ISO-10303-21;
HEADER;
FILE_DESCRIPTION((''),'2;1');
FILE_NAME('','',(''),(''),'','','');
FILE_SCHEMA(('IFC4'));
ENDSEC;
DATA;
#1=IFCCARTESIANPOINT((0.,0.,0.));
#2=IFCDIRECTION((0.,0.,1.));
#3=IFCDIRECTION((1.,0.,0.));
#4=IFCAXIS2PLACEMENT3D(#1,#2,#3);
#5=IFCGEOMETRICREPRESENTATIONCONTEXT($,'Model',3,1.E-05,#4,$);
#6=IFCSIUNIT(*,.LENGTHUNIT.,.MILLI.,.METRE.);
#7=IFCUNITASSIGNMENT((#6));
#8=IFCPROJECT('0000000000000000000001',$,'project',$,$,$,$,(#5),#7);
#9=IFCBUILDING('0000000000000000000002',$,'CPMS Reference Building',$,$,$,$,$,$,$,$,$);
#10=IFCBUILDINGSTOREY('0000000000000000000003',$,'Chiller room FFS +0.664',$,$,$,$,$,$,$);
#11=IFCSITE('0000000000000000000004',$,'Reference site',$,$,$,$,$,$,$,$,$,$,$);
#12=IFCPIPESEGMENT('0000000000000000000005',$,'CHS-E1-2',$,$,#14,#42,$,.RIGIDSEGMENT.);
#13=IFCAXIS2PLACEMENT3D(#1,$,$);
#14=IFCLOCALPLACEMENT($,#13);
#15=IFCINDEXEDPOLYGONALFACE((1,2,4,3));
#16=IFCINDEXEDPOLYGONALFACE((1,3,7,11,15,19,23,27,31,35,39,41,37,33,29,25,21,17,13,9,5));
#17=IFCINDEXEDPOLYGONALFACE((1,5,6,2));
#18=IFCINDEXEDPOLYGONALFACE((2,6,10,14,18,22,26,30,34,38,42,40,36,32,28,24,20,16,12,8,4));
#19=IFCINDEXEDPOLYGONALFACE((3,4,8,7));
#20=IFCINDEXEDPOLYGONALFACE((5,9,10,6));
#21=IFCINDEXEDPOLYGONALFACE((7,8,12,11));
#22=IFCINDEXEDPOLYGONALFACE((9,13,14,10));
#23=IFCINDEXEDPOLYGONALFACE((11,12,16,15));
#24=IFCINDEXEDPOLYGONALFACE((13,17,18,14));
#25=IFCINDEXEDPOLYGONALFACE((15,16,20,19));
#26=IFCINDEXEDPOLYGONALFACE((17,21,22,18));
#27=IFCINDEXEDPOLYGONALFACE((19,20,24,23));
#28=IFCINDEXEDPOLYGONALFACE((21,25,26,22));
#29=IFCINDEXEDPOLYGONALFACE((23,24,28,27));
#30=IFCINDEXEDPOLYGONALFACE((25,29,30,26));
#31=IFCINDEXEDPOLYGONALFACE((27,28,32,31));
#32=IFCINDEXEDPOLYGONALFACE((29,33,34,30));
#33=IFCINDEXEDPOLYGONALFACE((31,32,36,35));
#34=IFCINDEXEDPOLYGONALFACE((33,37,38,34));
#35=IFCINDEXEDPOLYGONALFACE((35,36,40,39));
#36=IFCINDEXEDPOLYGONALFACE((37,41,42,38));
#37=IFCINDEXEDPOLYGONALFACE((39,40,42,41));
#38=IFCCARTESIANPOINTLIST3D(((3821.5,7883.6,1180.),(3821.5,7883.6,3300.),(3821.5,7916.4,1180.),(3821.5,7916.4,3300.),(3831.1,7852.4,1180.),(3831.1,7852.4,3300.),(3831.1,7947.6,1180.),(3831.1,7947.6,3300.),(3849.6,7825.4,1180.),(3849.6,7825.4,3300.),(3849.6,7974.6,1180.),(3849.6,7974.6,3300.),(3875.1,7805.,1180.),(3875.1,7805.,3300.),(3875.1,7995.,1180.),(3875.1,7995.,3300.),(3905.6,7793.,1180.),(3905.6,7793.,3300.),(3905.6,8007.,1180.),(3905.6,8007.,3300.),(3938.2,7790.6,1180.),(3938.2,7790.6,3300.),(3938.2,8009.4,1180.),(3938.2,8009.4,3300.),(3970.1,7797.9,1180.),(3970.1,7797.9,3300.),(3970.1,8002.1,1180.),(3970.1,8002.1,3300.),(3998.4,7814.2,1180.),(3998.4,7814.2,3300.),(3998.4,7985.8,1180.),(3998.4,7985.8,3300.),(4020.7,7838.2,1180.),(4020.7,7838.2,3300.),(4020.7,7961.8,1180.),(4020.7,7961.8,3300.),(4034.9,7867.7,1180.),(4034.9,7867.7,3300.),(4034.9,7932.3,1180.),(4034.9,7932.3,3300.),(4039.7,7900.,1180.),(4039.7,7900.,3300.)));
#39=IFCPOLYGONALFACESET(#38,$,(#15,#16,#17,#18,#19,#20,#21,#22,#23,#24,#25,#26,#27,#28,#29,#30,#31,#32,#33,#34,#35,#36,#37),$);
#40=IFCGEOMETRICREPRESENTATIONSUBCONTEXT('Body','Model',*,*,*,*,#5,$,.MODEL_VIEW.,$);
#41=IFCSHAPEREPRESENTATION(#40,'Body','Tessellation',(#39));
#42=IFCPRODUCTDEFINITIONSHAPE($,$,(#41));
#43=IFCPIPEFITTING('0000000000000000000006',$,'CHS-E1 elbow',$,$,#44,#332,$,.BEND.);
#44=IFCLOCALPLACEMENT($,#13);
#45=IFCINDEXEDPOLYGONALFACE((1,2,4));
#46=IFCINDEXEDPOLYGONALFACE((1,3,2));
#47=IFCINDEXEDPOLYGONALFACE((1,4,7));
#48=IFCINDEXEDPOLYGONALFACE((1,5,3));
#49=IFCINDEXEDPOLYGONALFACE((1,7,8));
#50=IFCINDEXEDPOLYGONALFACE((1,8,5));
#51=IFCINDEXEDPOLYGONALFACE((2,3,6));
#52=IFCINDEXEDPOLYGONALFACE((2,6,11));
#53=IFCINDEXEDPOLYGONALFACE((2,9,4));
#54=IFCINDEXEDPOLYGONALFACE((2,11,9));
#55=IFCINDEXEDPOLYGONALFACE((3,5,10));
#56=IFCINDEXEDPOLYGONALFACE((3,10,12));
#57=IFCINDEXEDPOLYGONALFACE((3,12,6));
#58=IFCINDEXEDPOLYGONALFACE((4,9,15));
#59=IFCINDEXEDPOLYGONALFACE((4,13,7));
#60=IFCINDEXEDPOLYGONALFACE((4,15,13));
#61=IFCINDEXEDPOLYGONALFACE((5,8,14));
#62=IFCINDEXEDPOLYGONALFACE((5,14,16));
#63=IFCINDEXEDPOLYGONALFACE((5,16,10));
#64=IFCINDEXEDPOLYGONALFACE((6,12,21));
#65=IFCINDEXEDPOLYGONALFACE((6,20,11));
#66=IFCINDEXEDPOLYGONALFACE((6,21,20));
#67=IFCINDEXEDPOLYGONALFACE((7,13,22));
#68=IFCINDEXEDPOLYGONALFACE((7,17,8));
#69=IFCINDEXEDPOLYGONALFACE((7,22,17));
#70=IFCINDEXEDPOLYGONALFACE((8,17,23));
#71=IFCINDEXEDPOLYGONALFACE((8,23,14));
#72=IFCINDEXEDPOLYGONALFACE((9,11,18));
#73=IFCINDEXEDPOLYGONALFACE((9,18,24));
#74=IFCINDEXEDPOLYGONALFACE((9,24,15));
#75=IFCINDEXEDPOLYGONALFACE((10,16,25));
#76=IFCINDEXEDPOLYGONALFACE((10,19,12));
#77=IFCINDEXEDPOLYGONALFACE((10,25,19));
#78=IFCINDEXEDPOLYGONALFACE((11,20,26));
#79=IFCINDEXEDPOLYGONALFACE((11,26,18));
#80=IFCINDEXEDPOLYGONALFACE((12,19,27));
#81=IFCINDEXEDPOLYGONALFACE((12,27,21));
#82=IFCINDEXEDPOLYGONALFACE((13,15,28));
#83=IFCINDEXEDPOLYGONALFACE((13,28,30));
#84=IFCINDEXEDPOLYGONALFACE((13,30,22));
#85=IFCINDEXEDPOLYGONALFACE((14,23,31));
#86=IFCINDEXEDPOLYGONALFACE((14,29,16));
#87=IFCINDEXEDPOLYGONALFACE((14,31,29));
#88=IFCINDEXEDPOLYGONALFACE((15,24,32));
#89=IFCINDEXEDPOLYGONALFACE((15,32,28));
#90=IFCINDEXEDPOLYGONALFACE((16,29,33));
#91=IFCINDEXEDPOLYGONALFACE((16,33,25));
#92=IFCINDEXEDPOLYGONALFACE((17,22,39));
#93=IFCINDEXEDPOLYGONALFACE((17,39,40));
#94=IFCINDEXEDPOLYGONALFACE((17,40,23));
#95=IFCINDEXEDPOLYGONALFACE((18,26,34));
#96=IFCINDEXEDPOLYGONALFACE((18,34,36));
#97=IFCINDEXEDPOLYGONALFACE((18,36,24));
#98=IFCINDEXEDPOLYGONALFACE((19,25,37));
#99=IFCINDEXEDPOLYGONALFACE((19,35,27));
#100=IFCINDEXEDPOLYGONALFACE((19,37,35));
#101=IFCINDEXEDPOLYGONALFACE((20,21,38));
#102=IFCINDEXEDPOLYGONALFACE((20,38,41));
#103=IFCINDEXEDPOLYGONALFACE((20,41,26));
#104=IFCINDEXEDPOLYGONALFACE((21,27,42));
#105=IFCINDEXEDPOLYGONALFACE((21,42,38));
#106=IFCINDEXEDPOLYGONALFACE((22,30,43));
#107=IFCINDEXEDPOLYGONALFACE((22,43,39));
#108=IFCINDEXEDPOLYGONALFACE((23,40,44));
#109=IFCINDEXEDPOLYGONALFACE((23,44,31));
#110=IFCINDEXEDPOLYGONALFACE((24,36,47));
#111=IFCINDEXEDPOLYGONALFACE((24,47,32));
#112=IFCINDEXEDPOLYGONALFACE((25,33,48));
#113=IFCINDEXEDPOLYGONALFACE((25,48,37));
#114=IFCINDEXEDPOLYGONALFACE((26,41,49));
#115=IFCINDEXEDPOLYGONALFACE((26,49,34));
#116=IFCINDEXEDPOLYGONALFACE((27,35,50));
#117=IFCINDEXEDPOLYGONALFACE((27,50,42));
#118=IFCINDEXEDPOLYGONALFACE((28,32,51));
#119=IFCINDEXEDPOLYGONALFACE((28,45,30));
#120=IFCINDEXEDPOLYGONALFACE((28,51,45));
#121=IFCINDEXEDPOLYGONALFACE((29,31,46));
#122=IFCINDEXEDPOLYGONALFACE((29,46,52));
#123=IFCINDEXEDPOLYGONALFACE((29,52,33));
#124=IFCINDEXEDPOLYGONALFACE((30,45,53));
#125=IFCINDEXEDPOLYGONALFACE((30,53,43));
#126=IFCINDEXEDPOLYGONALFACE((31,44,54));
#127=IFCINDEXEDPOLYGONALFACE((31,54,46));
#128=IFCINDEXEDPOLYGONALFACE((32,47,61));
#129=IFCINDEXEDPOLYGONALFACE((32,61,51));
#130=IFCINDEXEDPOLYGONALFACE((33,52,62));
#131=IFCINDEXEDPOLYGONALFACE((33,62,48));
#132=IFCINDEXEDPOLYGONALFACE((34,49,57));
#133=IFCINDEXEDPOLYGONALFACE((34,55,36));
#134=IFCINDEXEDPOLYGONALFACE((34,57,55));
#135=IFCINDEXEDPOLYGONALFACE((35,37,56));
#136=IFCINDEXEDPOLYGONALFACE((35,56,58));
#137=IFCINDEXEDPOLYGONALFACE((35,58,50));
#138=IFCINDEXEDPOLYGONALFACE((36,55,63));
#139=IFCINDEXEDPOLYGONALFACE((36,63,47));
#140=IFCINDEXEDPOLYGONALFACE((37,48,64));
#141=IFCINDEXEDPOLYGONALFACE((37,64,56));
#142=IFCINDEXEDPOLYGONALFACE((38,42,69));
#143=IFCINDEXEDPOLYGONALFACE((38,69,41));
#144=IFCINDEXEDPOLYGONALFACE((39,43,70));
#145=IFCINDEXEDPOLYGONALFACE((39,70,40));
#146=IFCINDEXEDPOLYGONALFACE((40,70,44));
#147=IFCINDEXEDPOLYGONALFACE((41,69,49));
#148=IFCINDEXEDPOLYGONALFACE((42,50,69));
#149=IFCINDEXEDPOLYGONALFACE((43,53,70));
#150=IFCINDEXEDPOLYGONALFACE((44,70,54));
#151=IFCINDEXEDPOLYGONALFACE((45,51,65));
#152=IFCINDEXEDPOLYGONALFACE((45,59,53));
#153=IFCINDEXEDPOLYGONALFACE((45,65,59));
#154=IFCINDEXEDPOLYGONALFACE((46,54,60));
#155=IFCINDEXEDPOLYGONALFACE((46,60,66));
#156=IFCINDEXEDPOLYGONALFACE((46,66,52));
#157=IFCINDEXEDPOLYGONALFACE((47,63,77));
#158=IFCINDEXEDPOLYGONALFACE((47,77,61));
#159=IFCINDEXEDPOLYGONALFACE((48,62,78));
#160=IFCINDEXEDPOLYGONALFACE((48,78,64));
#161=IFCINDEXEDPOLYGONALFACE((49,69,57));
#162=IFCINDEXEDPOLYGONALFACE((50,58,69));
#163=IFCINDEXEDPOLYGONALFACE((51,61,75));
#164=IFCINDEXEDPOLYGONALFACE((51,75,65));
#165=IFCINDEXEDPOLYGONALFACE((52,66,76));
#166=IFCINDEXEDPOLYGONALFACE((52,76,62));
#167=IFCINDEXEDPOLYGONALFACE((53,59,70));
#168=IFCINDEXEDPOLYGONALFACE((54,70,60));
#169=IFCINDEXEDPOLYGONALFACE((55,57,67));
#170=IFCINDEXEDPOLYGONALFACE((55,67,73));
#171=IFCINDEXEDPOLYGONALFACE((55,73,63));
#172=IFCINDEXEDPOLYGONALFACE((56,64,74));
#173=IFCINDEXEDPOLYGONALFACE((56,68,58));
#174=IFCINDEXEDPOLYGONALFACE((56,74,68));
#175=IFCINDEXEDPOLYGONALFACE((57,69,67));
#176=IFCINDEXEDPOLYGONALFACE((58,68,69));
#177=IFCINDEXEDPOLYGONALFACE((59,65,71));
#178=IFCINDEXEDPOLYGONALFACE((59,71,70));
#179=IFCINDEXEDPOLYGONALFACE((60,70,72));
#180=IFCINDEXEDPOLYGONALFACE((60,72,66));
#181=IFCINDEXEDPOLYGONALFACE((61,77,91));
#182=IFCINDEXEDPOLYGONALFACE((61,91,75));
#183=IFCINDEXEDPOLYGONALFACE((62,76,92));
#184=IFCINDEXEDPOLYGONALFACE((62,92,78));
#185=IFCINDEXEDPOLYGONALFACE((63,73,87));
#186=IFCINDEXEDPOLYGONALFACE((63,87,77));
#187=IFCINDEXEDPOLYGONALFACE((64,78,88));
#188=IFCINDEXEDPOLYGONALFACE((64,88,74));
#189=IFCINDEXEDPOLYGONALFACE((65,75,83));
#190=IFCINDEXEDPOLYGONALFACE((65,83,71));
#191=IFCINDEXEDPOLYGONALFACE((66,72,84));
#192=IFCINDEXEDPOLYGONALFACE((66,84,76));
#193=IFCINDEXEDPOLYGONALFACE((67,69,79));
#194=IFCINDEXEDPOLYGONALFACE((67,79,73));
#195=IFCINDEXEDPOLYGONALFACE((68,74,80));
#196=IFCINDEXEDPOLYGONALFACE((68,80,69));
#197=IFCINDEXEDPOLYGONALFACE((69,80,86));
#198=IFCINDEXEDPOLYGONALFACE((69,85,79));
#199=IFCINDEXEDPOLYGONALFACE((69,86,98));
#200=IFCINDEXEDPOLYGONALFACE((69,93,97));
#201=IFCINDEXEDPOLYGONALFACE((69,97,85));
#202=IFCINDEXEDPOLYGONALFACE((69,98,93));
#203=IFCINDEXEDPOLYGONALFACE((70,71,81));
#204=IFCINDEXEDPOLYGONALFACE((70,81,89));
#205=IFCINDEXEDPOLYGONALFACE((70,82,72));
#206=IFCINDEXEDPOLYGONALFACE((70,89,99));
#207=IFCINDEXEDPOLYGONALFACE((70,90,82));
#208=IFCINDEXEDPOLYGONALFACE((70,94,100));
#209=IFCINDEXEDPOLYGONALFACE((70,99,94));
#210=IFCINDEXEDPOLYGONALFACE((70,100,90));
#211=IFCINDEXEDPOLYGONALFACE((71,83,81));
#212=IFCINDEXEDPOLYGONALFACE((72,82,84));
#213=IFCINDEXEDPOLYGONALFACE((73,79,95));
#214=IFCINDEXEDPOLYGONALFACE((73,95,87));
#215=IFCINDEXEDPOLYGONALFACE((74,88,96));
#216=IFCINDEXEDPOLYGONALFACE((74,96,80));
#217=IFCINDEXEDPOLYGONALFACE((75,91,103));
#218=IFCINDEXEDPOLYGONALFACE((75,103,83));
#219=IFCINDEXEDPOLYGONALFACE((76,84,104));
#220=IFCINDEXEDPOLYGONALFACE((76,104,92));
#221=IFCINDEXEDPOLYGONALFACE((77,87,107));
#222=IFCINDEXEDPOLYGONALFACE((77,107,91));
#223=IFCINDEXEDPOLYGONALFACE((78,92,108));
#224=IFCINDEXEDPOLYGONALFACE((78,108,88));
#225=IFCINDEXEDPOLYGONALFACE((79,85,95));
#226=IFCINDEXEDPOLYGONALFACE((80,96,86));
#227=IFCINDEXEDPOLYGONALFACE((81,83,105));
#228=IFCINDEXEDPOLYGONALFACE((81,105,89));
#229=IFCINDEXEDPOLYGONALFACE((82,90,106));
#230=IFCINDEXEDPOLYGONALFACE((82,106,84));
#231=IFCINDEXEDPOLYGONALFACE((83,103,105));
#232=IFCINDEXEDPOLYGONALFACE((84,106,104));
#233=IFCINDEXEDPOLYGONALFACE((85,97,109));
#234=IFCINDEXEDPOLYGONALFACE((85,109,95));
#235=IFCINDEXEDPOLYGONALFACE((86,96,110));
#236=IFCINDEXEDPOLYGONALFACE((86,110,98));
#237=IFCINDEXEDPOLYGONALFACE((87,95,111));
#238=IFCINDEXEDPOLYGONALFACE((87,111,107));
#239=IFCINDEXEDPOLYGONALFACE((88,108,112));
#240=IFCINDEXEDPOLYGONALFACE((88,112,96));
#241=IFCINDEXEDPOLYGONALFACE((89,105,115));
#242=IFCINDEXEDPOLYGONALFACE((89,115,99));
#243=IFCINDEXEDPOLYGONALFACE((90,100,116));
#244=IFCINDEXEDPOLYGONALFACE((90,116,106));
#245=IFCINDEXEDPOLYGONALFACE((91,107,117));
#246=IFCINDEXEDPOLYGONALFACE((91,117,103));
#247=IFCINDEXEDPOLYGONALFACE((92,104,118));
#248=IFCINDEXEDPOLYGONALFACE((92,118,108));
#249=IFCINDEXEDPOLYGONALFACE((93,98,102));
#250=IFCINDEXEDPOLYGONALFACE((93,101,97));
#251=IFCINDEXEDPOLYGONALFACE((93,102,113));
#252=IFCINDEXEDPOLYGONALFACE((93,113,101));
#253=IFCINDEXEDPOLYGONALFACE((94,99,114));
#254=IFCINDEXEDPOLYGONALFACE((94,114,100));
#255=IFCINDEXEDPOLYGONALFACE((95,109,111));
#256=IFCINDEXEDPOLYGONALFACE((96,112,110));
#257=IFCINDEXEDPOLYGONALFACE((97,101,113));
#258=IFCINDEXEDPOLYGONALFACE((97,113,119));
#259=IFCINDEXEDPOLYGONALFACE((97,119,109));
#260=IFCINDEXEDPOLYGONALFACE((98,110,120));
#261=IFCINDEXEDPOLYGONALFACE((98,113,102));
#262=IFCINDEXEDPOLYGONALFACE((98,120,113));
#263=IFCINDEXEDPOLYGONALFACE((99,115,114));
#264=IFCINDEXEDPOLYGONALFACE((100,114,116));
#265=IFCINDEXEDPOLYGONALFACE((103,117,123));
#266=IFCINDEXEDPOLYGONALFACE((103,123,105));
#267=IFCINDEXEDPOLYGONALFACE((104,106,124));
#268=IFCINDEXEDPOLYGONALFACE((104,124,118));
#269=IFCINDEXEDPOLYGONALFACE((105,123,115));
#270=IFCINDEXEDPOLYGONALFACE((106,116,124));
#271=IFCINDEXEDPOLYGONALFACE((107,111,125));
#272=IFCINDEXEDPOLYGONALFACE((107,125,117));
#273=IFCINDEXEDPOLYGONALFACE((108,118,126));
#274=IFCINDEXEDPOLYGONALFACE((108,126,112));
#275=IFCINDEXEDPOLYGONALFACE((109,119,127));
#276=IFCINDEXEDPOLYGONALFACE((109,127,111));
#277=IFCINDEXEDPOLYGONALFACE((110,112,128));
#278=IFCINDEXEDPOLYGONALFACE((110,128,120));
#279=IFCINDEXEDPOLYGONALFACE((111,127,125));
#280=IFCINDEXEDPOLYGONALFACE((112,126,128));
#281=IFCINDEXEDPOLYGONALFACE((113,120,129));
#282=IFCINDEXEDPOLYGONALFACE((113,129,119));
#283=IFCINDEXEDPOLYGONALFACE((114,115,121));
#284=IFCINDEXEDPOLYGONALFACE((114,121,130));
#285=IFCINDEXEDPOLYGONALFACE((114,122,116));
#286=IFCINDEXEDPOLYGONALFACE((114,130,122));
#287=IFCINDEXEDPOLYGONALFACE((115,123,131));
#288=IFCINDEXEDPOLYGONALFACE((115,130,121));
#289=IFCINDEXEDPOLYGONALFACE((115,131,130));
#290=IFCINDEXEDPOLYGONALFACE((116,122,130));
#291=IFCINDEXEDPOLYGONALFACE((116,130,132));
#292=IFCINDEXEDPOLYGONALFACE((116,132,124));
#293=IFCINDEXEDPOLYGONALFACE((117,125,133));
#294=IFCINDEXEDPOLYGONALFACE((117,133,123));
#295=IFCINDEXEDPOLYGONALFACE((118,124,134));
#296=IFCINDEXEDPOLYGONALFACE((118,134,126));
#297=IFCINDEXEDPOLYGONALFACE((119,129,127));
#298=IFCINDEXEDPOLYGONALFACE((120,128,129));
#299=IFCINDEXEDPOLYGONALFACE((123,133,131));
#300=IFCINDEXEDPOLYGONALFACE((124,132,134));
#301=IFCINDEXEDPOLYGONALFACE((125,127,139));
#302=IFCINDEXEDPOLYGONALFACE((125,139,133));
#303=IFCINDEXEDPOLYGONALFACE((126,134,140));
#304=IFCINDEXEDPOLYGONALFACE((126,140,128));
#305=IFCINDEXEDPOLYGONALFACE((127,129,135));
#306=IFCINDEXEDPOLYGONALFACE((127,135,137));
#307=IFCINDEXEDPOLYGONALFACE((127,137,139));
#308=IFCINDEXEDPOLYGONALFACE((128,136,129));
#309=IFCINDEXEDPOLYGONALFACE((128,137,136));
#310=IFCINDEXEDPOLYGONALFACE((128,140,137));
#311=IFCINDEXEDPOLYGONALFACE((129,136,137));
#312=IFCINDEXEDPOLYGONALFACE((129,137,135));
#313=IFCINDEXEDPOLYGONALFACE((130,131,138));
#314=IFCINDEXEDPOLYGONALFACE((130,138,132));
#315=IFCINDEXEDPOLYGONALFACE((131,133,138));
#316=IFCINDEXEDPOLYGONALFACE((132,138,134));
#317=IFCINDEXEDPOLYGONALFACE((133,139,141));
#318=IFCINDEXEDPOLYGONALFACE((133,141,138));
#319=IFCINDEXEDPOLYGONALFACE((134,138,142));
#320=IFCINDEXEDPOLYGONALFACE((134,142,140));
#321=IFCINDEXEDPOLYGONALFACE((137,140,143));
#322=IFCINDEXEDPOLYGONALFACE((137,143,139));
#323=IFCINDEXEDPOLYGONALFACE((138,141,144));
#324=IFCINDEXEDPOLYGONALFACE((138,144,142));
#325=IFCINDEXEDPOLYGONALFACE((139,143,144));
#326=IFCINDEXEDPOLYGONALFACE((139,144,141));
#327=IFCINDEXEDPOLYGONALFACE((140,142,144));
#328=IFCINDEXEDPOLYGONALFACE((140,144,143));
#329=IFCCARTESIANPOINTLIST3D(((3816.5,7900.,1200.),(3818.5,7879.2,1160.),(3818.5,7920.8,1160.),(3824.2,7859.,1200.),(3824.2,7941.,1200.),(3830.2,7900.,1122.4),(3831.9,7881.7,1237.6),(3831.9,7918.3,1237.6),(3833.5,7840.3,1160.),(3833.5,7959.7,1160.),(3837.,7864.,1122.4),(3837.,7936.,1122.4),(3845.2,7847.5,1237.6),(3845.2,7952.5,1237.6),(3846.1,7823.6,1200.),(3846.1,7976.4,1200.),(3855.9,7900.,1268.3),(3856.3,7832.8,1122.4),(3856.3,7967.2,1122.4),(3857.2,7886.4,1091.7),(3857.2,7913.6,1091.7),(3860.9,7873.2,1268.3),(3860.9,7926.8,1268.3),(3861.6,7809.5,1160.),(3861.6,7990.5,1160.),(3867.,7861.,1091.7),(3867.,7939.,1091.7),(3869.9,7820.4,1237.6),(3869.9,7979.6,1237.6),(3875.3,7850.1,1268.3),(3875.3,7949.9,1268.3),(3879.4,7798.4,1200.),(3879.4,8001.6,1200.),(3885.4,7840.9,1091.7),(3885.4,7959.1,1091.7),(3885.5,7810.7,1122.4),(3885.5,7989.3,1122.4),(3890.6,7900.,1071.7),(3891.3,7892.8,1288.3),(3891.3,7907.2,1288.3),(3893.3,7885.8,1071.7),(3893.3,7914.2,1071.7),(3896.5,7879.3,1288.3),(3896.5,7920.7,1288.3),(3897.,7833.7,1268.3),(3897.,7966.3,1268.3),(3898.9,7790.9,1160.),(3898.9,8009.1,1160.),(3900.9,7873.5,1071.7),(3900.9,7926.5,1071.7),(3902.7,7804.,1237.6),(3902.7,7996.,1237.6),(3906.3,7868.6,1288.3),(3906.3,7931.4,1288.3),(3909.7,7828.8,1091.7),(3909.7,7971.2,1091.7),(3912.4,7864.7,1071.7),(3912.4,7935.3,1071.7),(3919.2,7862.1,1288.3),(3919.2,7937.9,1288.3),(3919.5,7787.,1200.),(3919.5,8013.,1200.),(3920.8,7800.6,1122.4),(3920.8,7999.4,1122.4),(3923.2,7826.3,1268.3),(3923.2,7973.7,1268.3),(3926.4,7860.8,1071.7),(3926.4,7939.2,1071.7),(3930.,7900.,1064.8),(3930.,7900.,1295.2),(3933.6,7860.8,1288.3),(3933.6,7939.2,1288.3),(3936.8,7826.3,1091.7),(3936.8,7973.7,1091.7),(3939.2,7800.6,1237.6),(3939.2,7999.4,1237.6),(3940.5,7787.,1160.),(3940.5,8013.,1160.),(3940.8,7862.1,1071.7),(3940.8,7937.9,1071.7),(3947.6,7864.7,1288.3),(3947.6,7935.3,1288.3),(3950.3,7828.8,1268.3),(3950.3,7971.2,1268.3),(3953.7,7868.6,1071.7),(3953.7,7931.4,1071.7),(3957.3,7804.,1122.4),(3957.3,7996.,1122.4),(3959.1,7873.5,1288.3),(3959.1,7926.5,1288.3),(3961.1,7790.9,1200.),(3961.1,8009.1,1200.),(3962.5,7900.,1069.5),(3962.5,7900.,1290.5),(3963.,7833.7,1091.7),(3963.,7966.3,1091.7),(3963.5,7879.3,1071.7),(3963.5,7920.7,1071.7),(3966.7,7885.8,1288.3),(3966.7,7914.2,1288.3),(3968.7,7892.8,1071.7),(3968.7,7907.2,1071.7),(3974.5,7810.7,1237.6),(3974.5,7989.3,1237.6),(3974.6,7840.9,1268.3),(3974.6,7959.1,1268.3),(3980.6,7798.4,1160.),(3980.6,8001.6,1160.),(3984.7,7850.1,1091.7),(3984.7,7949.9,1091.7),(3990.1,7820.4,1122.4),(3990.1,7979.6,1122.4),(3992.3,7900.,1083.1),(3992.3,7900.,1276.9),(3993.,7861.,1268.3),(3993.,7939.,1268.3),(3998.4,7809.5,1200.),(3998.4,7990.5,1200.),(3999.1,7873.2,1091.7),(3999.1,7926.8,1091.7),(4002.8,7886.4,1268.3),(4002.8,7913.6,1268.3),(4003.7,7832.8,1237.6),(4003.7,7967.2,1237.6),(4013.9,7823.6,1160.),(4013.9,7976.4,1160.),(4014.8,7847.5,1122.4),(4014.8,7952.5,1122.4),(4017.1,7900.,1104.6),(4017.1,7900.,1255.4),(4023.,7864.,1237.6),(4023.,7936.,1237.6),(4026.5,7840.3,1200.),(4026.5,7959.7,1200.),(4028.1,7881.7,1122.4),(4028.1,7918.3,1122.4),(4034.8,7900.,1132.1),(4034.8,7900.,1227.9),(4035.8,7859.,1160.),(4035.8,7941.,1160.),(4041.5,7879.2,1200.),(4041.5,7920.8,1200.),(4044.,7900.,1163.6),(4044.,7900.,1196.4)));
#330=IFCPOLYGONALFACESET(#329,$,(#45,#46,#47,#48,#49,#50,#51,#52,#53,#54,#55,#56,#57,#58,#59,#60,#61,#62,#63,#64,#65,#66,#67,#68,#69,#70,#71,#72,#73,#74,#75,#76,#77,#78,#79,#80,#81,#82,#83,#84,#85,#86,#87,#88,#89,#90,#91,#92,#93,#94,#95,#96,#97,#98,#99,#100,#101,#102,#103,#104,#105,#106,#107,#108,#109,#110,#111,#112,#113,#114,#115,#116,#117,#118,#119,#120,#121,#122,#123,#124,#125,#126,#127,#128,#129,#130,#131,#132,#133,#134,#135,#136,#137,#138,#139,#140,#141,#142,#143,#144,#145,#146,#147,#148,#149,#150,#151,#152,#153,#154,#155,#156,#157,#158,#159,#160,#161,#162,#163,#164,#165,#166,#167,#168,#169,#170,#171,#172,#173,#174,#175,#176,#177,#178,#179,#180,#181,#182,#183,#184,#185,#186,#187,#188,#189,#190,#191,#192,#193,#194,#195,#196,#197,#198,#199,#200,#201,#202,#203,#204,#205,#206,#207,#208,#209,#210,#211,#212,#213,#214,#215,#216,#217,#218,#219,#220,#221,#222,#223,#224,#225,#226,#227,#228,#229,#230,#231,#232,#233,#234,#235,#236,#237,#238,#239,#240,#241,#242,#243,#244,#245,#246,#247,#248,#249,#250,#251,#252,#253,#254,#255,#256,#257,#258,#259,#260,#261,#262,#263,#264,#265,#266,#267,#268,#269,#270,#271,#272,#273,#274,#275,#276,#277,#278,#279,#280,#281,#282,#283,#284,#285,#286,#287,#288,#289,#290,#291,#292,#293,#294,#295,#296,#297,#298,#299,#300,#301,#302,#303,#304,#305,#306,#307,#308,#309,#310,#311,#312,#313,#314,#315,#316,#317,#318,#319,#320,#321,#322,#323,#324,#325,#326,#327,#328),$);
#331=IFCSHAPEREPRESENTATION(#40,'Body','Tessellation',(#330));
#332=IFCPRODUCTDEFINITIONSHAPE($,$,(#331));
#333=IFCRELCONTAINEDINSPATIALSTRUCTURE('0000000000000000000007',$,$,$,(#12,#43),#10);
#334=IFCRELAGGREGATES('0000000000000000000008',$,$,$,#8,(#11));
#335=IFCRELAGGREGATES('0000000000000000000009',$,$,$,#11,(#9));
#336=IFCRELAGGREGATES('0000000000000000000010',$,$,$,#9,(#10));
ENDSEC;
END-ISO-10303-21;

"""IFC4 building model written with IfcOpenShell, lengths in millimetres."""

from ifc_helpers import new_model, entity, si_unit, frame, origin_with_axes, origin_2d, place, context, subcontext, project, spatial, circle_curve, outline, extrude, element, save


model = new_model("IFC4")

# Units and contexts
model_context = context("Model", 3, precision=1e-05, world=origin_with_axes())
body_context = subcontext(model_context, "Body", "Model", "MODEL_VIEW")
ifc_project = project(units=[si_unit("LENGTHUNIT", "METRE", prefix="MILLI")], contexts=[model_context])

# Site, building, storey
site = spatial("IfcSite", under=ifc_project, Name="Reference site")
building = spatial("IfcBuilding", under=site, Name="CPMS Reference Building")
storey = spatial("IfcBuildingStorey", under=building, Name="Chiller room FFS +0.664")

# Pipe segment
pipe_segment_1_placement = place(None, origin_with_axes())
element("IfcPipeSegment", 1, at=pipe_segment_1_placement, inside=storey, Name="CHS-E1-2", PredefinedType="RIGIDSEGMENT", context=body_context, shape_type="SweptSolid", body=[
    extrude(outline(circle_curve(origin_2d(), 109.7)), frame((3930.0, 7900.0, 1180.0), z_axis=(0.0, 0.0, 1.0), x_axis=(1.0, 0.0, 0.0)), (0.0, 0.0, 1.0), 2120.0),
])

# Pipe fitting
pipe_fitting_1_placement = place(None, origin_with_axes())
element("IfcPipeFitting", 2, at=pipe_fitting_1_placement, inside=storey, Name="CHS-E1 elbow", PredefinedType="BEND", context=body_context, shape_type="CSG", body=[
    entity("IfcSphere", entity("IfcAxis2Placement3D", entity("IfcCartesianPoint", [3930.0, 7900.0, 1180.0]), entity("IfcDirection", [0.0, 0.0, 1.0]), entity("IfcDirection", [1.0, 0.0, 0.0])), 115.2),
])

save(model, "model.ifc")
